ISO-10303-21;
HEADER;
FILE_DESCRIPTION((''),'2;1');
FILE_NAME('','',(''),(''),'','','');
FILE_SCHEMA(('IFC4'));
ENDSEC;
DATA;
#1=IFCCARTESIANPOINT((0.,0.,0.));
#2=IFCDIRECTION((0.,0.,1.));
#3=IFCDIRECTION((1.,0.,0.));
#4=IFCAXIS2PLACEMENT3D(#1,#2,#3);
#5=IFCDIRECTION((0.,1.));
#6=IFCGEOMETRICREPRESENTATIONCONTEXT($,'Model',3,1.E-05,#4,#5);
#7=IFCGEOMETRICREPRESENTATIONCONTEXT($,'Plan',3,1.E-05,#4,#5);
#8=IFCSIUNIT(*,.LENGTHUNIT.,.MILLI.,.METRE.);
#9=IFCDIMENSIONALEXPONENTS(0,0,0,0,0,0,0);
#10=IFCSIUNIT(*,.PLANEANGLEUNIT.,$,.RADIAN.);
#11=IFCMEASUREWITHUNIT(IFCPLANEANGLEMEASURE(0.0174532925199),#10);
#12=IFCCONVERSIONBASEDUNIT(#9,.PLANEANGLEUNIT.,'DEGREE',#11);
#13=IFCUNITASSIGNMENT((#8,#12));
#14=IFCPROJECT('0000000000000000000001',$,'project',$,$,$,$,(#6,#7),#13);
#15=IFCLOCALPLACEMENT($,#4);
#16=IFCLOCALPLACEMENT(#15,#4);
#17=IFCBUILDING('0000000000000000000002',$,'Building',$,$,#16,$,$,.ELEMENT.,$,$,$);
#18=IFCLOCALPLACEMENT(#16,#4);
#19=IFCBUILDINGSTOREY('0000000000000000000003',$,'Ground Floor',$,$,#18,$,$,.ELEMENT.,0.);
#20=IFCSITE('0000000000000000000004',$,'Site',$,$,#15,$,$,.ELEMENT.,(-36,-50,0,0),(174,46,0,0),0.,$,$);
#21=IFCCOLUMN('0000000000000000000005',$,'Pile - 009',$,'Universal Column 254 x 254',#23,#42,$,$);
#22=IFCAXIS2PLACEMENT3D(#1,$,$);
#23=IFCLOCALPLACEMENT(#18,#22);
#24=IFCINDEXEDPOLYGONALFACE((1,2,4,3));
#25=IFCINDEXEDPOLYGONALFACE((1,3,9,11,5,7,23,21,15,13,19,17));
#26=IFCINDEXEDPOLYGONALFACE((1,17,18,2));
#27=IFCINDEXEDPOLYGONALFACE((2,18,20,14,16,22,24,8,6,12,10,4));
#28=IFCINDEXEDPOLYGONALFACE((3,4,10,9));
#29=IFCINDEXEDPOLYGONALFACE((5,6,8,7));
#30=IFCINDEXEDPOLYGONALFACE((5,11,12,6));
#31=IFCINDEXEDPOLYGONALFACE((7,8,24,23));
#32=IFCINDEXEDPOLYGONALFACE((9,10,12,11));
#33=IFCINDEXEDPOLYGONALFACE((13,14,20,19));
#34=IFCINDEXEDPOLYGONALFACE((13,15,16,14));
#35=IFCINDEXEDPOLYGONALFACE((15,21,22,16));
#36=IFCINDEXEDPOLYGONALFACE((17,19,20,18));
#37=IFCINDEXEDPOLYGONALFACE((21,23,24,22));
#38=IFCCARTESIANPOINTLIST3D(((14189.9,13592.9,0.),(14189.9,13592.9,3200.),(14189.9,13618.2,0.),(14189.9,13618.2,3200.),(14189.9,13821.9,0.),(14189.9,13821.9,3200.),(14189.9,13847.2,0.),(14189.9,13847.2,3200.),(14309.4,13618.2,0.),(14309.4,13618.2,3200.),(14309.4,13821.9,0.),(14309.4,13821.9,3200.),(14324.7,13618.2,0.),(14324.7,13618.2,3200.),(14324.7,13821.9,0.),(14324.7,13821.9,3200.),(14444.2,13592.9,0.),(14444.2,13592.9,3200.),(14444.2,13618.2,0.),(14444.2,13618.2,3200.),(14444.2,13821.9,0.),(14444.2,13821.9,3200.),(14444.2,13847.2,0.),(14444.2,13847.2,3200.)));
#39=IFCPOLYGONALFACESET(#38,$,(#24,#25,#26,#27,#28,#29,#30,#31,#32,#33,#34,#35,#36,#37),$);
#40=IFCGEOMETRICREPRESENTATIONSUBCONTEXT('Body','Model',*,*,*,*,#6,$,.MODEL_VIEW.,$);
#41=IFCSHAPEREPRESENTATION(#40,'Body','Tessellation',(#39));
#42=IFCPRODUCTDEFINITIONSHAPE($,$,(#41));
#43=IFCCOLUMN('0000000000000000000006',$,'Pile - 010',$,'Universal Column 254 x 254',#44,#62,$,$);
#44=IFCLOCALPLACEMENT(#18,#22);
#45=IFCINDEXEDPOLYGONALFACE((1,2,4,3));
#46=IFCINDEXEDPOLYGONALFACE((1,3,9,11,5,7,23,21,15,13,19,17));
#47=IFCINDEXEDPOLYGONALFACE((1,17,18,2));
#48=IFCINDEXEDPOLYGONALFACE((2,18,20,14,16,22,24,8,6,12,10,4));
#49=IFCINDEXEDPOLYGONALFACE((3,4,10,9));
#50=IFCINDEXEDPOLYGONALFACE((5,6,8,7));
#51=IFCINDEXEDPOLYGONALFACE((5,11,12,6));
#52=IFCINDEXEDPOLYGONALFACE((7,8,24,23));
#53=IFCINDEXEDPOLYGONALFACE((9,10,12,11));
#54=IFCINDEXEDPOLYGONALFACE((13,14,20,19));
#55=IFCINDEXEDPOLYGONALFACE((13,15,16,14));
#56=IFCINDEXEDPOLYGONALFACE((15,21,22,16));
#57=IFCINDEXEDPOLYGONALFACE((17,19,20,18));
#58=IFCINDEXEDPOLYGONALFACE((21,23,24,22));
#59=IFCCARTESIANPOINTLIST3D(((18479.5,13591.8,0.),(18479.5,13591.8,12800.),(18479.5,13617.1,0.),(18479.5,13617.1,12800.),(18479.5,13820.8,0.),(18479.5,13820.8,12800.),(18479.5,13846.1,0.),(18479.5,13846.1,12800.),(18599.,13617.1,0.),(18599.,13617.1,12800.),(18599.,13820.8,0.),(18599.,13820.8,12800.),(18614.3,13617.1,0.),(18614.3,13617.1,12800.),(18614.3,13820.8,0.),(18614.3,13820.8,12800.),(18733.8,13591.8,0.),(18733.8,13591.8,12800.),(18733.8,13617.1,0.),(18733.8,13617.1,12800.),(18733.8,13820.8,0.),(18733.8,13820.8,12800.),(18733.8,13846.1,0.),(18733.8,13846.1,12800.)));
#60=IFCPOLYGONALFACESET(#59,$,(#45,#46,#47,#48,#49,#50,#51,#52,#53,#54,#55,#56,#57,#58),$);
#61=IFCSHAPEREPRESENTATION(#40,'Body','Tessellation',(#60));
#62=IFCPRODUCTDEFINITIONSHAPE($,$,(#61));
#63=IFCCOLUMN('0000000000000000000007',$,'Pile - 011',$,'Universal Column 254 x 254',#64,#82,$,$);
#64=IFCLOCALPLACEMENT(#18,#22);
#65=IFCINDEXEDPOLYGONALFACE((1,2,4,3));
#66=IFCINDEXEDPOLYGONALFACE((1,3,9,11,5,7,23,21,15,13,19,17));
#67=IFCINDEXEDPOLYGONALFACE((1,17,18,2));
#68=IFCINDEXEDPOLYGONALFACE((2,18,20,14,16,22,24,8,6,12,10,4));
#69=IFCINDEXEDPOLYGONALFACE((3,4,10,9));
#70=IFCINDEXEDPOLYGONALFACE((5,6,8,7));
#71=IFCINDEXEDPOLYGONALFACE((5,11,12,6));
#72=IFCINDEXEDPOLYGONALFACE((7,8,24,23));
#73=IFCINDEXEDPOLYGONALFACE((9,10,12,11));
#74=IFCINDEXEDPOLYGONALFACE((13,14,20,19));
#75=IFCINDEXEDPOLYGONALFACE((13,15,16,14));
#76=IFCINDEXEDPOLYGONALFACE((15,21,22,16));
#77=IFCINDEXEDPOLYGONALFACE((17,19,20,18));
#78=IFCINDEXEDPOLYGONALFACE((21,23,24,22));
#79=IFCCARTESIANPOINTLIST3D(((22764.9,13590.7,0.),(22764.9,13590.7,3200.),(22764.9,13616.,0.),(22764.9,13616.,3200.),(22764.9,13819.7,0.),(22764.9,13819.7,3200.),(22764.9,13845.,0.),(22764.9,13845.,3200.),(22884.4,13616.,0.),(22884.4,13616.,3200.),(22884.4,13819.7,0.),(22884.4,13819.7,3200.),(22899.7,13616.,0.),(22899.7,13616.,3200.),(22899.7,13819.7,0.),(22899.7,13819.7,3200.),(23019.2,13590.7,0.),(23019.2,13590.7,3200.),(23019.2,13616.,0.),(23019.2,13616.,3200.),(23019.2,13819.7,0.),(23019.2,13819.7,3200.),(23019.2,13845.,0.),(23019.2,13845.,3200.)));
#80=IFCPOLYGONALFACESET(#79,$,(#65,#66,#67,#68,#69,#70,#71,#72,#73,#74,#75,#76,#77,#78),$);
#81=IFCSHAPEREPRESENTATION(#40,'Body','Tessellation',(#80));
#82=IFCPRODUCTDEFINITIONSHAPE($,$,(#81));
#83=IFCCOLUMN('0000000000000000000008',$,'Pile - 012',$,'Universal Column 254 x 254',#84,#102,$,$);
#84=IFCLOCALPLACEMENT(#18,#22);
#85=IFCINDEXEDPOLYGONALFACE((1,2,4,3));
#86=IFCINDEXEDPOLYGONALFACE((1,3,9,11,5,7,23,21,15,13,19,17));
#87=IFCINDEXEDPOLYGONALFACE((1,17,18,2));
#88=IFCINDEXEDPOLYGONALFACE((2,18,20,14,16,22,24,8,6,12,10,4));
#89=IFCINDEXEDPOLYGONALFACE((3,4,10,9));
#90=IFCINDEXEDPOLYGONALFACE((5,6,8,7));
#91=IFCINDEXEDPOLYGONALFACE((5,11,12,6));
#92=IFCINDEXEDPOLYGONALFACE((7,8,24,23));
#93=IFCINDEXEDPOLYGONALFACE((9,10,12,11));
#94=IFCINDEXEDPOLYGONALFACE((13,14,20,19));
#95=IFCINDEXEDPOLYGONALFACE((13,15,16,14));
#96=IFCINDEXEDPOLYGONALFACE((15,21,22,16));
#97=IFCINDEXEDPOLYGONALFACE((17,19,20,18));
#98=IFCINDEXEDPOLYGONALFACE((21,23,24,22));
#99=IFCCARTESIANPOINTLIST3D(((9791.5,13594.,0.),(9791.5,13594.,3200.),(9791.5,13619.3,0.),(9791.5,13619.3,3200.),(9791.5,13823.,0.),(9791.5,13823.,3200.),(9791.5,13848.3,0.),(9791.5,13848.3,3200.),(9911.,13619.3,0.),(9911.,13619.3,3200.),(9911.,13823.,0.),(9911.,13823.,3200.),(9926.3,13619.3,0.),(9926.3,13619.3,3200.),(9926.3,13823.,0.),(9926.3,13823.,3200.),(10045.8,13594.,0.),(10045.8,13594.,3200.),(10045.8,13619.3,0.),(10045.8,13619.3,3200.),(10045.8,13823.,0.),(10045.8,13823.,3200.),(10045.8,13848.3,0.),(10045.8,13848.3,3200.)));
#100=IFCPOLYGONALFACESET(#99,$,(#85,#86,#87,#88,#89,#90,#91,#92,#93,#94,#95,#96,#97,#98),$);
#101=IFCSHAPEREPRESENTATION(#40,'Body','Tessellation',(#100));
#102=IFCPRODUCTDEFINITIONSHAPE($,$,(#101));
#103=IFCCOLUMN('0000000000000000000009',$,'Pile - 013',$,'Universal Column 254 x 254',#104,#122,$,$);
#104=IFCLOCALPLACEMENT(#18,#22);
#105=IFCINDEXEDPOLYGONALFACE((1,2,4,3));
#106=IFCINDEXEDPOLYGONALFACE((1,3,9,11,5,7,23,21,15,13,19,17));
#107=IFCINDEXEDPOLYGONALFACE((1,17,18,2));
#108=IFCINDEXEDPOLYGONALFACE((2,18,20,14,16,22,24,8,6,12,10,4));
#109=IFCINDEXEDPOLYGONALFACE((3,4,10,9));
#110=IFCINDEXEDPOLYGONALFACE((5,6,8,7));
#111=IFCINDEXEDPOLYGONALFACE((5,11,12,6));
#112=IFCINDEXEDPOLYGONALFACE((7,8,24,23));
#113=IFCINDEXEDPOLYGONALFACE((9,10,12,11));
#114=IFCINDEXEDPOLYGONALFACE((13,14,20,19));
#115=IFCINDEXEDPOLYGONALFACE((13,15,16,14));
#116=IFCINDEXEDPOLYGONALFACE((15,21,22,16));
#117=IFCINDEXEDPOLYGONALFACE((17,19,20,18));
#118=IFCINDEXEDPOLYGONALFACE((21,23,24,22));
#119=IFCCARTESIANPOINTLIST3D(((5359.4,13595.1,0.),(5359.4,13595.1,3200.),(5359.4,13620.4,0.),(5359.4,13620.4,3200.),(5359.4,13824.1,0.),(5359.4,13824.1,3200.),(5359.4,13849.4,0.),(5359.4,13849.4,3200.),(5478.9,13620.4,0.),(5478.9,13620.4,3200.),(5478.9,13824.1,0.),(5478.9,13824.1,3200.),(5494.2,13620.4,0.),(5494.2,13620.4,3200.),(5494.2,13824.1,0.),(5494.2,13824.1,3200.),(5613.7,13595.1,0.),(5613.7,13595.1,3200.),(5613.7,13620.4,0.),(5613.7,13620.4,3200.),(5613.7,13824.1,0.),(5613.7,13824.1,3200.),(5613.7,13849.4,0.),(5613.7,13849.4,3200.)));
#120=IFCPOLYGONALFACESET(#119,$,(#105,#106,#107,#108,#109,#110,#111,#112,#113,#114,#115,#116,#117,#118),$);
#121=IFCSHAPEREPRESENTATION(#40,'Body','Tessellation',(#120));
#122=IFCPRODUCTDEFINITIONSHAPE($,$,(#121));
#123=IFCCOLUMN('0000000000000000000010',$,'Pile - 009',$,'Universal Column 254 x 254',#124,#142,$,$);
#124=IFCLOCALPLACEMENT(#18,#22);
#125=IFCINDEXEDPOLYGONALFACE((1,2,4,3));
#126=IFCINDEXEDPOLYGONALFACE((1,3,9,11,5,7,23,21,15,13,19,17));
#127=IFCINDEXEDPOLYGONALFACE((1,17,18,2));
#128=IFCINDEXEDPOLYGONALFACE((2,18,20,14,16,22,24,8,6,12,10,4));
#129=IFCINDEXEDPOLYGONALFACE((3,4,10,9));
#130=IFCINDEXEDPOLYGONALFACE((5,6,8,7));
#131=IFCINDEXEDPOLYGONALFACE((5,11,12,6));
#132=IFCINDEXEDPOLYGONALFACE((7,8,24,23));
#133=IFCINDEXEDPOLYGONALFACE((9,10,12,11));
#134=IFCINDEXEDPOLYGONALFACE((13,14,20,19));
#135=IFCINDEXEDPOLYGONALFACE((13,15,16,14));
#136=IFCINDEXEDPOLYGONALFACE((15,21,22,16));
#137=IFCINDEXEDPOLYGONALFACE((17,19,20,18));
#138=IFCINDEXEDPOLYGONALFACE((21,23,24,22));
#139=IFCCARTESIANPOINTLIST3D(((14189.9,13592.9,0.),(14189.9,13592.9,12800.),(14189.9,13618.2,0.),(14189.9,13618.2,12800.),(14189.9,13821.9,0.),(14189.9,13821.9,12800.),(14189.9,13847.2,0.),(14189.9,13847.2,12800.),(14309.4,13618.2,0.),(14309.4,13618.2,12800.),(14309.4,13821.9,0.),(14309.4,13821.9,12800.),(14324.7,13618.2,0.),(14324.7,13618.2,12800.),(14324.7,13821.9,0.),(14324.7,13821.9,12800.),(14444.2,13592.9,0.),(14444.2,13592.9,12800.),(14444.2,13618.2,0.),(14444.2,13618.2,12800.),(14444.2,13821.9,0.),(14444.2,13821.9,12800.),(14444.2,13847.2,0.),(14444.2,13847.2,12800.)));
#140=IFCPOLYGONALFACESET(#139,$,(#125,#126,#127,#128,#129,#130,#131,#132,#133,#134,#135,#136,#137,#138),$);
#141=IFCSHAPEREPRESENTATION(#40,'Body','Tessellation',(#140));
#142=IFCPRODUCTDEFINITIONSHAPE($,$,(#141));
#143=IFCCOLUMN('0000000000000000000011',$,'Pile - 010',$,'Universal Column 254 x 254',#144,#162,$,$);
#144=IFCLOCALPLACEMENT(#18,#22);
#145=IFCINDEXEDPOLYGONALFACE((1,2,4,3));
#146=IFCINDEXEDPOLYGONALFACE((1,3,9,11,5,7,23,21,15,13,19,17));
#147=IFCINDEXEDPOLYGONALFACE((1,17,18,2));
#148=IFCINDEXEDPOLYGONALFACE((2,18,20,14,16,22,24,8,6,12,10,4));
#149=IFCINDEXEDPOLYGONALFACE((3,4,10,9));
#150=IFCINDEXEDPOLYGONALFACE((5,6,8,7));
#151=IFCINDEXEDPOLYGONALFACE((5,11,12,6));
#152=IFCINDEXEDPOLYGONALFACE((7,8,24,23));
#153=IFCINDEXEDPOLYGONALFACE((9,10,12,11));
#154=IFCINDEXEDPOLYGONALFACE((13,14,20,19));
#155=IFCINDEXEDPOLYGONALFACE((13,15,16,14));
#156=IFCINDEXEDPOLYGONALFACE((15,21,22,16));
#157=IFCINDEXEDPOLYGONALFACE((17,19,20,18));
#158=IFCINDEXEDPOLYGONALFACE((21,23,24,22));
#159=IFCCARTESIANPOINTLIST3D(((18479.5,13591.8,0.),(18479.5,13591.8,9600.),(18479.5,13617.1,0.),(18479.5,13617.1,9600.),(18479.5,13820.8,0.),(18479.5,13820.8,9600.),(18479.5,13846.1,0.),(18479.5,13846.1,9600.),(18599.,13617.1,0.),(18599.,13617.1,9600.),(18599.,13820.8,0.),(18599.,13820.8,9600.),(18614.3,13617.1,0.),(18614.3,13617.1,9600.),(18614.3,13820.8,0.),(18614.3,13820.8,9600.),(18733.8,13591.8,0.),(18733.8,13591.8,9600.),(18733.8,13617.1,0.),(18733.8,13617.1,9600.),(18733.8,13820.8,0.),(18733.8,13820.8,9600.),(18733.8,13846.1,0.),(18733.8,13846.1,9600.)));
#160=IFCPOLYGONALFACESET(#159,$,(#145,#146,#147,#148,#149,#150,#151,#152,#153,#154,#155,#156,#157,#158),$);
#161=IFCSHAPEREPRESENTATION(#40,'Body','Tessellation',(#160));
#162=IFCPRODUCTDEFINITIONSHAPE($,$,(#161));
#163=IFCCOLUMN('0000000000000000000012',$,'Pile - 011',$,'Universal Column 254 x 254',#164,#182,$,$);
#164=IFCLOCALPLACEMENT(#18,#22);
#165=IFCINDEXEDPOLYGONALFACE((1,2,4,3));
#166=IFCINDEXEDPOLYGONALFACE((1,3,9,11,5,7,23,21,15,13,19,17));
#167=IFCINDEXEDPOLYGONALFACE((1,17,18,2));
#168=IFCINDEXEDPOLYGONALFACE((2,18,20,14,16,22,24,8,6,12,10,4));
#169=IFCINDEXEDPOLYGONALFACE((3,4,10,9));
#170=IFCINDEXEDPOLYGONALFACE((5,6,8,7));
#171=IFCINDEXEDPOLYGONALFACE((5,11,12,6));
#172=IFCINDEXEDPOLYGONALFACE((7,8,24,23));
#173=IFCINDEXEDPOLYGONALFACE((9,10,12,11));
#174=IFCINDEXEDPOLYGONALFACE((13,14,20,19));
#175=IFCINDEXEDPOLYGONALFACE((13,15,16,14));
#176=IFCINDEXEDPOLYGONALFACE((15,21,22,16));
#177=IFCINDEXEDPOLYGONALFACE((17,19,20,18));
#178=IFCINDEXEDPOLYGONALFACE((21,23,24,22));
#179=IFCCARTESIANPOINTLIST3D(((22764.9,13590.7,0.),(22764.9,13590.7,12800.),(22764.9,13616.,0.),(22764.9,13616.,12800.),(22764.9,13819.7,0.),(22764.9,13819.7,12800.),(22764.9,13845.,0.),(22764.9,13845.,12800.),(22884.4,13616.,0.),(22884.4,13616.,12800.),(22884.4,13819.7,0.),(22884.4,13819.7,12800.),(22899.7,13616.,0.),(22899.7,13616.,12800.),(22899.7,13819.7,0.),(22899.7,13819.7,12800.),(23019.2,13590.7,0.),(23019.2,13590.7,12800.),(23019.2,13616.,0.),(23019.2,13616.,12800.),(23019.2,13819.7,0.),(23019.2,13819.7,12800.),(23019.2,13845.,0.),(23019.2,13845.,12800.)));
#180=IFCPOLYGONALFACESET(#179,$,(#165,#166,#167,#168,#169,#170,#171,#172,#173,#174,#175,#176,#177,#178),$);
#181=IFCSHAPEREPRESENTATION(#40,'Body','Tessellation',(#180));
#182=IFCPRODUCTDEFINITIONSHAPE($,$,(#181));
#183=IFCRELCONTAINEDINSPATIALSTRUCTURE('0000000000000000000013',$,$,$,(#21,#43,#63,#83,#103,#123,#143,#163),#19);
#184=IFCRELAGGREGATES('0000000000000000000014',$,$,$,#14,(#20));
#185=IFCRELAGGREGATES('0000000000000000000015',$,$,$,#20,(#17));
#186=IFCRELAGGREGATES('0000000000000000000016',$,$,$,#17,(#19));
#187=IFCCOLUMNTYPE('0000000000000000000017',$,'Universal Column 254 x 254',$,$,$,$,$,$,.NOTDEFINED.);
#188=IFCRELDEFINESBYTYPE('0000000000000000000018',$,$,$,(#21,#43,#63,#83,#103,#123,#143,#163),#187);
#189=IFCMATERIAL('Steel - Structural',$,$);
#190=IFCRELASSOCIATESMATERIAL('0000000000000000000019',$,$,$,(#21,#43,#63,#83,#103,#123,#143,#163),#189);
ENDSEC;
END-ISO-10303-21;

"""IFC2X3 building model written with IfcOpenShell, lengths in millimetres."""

from ifc_helpers import new_model, entity, si_unit, converted_unit, direction, frame, origin_with_axes, place, context, subcontext, project, spatial, polyline, outline, extrude, material, type_object, element, save


model = new_model("IFC2X3")

# Units and contexts
model_context = context("Model", 3, precision=1e-05, world=origin_with_axes(), true_north=direction((0.0, 1.0)))
plan_context = context("Plan", 3, precision=1e-05, world=origin_with_axes(), true_north=direction((0.0, 1.0)))
body_context = subcontext(model_context, "Body", "Model", "MODEL_VIEW")
ifc_project = project(units=[si_unit("LENGTHUNIT", "METRE", prefix="MILLI"), converted_unit("PLANEANGLEUNIT", "DEGREE", entity("IfcPlaneAngleMeasure", 0.0174532925199), si_unit("PLANEANGLEUNIT", "RADIAN"), dimensions=[0, 0, 0, 0, 0, 0, 0])], contexts=[model_context, plan_context])

# Site, building, storey
site_placement = place(None, origin_with_axes())
site = spatial("IfcSite", under=ifc_project, at=site_placement, Name="Site", CompositionType="ELEMENT", RefLatitude=(-36, -50, 0, 0), RefLongitude=(174, 46, 0, 0), RefElevation=0.0)
building_placement = place(site_placement, origin_with_axes())
building = spatial("IfcBuilding", under=site, at=building_placement, Name="Building", CompositionType="ELEMENT")
storey_placement = place(building_placement, origin_with_axes())
storey = spatial("IfcBuildingStorey", under=building, at=storey_placement, Name="Ground Floor", CompositionType="ELEMENT", Elevation=0.0)

# Columns
ifc_material_1 = material(Name="Steel - Structural")
column_type = type_object("IfcColumnType", Name="Universal Column 254 x 254", PredefinedType="NOTDEFINED")
column_1_placement = place(storey_placement, frame((14317.0, 13720.0, 0.0), z_axis=(0.0, 0.0, 1.0), x_axis=(1.0, 0.0, 0.0)))
element("IfcColumn", 1, at=column_1_placement, inside=storey, type_object=column_type, material=ifc_material_1, Name="Pile - 009", ObjectType="Universal Column 254 x 254", context=body_context, shape_type="SweptSolid", body=[
    extrude(outline(polyline([(-127.2, -127.2), (127.2, -127.2), (127.2, -101.8), (7.7, -101.8), (7.7, 101.8), (127.2, 101.8), (127.2, 127.2), (-127.2, 127.2), (-127.2, 101.8), (-7.7, 101.8), (-7.7, -101.8), (-127.2, -101.8), (-127.2, -127.2)])), origin_with_axes(), (0.0, 0.0, 1.0), 3200.0),
])
column_2_placement = place(storey_placement, frame((18606.7, 13718.9, 0.0), z_axis=(0.0, 0.0, 1.0), x_axis=(1.0, 0.0, 0.0)))
element("IfcColumn", 2, at=column_2_placement, inside=storey, type_object=column_type, material=ifc_material_1, Name="Pile - 010", ObjectType="Universal Column 254 x 254", context=body_context, shape_type="SweptSolid", body=[
    extrude(outline(polyline([(-127.2, -127.2), (127.2, -127.2), (127.2, -101.8), (7.7, -101.8), (7.7, 101.8), (127.2, 101.8), (127.2, 127.2), (-127.2, 127.2), (-127.2, 101.8), (-7.7, 101.8), (-7.7, -101.8), (-127.2, -101.8), (-127.2, -127.2)])), origin_with_axes(), (0.0, 0.0, 1.0), 12800.0),
])
for number, where, z_axis, x_axis, name in (
    (3, (22892.0, 13717.8, 0.0), (0.0, 0.0, 1.0), (1.0, 0.0, 0.0), "Pile - 011"),
    (4, (9918.6, 13721.1, 0.0), (0.0, 0.0, 1.0), (1.0, 0.0, 0.0), "Pile - 012"),
    (5, (5486.6, 13722.3, 0.0), (0.0, 0.0, 1.0), (1.0, 0.0, 0.0), "Pile - 013"),
):
    element("IfcColumn", number, at=place(storey_placement, frame(where, z_axis=z_axis, x_axis=x_axis)), inside=storey, type_object=column_type, material=ifc_material_1, Name=name, ObjectType="Universal Column 254 x 254", context=body_context, shape_type="SweptSolid", body=[
        extrude(outline(polyline([(-127.2, -127.2), (127.2, -127.2), (127.2, -101.8), (7.7, -101.8), (7.7, 101.8), (127.2, 101.8), (127.2, 127.2), (-127.2, 127.2), (-127.2, 101.8), (-7.7, 101.8), (-7.7, -101.8), (-127.2, -101.8), (-127.2, -127.2)])), origin_with_axes(), (0.0, 0.0, 1.0), 3200.0),
    ])
column_3_placement = place(storey_placement, frame((14317.0, 13720.0, 0.0), z_axis=(0.0, 0.0, 1.0), x_axis=(1.0, 0.0, 0.0)))
element("IfcColumn", 6, at=column_3_placement, inside=storey, type_object=column_type, material=ifc_material_1, Name="Pile - 009", ObjectType="Universal Column 254 x 254", context=body_context, shape_type="SweptSolid", body=[
    extrude(outline(polyline([(-127.2, -127.2), (127.2, -127.2), (127.2, -101.8), (7.7, -101.8), (7.7, 101.8), (127.2, 101.8), (127.2, 127.2), (-127.2, 127.2), (-127.2, 101.8), (-7.7, 101.8), (-7.7, -101.8), (-127.2, -101.8), (-127.2, -127.2)])), origin_with_axes(), (0.0, 0.0, 1.0), 12800.0),
])
column_4_placement = place(storey_placement, frame((18606.7, 13718.9, 0.0), z_axis=(0.0, 0.0, 1.0), x_axis=(1.0, 0.0, 0.0)))
element("IfcColumn", 7, at=column_4_placement, inside=storey, type_object=column_type, material=ifc_material_1, Name="Pile - 010", ObjectType="Universal Column 254 x 254", context=body_context, shape_type="SweptSolid", body=[
    extrude(outline(polyline([(-127.2, -127.2), (127.2, -127.2), (127.2, -101.8), (7.7, -101.8), (7.7, 101.8), (127.2, 101.8), (127.2, 127.2), (-127.2, 127.2), (-127.2, 101.8), (-7.7, 101.8), (-7.7, -101.8), (-127.2, -101.8), (-127.2, -127.2)])), origin_with_axes(), (0.0, 0.0, 1.0), 9600.0),
])
for number, where, z_axis, x_axis, name in (
    (8, (22892.0, 13717.8, 0.0), (0.0, 0.0, 1.0), (1.0, 0.0, 0.0), "Pile - 011"),
):
    element("IfcColumn", number, at=place(storey_placement, frame(where, z_axis=z_axis, x_axis=x_axis)), inside=storey, type_object=column_type, material=ifc_material_1, Name=name, ObjectType="Universal Column 254 x 254", context=body_context, shape_type="SweptSolid", body=[
        extrude(outline(polyline([(-127.2, -127.2), (127.2, -127.2), (127.2, -101.8), (7.7, -101.8), (7.7, 101.8), (127.2, 101.8), (127.2, 127.2), (-127.2, 127.2), (-127.2, 101.8), (-7.7, 101.8), (-7.7, -101.8), (-127.2, -101.8), (-127.2, -127.2)])), origin_with_axes(), (0.0, 0.0, 1.0), 12800.0),
    ])

save(model, "model.ifc")
